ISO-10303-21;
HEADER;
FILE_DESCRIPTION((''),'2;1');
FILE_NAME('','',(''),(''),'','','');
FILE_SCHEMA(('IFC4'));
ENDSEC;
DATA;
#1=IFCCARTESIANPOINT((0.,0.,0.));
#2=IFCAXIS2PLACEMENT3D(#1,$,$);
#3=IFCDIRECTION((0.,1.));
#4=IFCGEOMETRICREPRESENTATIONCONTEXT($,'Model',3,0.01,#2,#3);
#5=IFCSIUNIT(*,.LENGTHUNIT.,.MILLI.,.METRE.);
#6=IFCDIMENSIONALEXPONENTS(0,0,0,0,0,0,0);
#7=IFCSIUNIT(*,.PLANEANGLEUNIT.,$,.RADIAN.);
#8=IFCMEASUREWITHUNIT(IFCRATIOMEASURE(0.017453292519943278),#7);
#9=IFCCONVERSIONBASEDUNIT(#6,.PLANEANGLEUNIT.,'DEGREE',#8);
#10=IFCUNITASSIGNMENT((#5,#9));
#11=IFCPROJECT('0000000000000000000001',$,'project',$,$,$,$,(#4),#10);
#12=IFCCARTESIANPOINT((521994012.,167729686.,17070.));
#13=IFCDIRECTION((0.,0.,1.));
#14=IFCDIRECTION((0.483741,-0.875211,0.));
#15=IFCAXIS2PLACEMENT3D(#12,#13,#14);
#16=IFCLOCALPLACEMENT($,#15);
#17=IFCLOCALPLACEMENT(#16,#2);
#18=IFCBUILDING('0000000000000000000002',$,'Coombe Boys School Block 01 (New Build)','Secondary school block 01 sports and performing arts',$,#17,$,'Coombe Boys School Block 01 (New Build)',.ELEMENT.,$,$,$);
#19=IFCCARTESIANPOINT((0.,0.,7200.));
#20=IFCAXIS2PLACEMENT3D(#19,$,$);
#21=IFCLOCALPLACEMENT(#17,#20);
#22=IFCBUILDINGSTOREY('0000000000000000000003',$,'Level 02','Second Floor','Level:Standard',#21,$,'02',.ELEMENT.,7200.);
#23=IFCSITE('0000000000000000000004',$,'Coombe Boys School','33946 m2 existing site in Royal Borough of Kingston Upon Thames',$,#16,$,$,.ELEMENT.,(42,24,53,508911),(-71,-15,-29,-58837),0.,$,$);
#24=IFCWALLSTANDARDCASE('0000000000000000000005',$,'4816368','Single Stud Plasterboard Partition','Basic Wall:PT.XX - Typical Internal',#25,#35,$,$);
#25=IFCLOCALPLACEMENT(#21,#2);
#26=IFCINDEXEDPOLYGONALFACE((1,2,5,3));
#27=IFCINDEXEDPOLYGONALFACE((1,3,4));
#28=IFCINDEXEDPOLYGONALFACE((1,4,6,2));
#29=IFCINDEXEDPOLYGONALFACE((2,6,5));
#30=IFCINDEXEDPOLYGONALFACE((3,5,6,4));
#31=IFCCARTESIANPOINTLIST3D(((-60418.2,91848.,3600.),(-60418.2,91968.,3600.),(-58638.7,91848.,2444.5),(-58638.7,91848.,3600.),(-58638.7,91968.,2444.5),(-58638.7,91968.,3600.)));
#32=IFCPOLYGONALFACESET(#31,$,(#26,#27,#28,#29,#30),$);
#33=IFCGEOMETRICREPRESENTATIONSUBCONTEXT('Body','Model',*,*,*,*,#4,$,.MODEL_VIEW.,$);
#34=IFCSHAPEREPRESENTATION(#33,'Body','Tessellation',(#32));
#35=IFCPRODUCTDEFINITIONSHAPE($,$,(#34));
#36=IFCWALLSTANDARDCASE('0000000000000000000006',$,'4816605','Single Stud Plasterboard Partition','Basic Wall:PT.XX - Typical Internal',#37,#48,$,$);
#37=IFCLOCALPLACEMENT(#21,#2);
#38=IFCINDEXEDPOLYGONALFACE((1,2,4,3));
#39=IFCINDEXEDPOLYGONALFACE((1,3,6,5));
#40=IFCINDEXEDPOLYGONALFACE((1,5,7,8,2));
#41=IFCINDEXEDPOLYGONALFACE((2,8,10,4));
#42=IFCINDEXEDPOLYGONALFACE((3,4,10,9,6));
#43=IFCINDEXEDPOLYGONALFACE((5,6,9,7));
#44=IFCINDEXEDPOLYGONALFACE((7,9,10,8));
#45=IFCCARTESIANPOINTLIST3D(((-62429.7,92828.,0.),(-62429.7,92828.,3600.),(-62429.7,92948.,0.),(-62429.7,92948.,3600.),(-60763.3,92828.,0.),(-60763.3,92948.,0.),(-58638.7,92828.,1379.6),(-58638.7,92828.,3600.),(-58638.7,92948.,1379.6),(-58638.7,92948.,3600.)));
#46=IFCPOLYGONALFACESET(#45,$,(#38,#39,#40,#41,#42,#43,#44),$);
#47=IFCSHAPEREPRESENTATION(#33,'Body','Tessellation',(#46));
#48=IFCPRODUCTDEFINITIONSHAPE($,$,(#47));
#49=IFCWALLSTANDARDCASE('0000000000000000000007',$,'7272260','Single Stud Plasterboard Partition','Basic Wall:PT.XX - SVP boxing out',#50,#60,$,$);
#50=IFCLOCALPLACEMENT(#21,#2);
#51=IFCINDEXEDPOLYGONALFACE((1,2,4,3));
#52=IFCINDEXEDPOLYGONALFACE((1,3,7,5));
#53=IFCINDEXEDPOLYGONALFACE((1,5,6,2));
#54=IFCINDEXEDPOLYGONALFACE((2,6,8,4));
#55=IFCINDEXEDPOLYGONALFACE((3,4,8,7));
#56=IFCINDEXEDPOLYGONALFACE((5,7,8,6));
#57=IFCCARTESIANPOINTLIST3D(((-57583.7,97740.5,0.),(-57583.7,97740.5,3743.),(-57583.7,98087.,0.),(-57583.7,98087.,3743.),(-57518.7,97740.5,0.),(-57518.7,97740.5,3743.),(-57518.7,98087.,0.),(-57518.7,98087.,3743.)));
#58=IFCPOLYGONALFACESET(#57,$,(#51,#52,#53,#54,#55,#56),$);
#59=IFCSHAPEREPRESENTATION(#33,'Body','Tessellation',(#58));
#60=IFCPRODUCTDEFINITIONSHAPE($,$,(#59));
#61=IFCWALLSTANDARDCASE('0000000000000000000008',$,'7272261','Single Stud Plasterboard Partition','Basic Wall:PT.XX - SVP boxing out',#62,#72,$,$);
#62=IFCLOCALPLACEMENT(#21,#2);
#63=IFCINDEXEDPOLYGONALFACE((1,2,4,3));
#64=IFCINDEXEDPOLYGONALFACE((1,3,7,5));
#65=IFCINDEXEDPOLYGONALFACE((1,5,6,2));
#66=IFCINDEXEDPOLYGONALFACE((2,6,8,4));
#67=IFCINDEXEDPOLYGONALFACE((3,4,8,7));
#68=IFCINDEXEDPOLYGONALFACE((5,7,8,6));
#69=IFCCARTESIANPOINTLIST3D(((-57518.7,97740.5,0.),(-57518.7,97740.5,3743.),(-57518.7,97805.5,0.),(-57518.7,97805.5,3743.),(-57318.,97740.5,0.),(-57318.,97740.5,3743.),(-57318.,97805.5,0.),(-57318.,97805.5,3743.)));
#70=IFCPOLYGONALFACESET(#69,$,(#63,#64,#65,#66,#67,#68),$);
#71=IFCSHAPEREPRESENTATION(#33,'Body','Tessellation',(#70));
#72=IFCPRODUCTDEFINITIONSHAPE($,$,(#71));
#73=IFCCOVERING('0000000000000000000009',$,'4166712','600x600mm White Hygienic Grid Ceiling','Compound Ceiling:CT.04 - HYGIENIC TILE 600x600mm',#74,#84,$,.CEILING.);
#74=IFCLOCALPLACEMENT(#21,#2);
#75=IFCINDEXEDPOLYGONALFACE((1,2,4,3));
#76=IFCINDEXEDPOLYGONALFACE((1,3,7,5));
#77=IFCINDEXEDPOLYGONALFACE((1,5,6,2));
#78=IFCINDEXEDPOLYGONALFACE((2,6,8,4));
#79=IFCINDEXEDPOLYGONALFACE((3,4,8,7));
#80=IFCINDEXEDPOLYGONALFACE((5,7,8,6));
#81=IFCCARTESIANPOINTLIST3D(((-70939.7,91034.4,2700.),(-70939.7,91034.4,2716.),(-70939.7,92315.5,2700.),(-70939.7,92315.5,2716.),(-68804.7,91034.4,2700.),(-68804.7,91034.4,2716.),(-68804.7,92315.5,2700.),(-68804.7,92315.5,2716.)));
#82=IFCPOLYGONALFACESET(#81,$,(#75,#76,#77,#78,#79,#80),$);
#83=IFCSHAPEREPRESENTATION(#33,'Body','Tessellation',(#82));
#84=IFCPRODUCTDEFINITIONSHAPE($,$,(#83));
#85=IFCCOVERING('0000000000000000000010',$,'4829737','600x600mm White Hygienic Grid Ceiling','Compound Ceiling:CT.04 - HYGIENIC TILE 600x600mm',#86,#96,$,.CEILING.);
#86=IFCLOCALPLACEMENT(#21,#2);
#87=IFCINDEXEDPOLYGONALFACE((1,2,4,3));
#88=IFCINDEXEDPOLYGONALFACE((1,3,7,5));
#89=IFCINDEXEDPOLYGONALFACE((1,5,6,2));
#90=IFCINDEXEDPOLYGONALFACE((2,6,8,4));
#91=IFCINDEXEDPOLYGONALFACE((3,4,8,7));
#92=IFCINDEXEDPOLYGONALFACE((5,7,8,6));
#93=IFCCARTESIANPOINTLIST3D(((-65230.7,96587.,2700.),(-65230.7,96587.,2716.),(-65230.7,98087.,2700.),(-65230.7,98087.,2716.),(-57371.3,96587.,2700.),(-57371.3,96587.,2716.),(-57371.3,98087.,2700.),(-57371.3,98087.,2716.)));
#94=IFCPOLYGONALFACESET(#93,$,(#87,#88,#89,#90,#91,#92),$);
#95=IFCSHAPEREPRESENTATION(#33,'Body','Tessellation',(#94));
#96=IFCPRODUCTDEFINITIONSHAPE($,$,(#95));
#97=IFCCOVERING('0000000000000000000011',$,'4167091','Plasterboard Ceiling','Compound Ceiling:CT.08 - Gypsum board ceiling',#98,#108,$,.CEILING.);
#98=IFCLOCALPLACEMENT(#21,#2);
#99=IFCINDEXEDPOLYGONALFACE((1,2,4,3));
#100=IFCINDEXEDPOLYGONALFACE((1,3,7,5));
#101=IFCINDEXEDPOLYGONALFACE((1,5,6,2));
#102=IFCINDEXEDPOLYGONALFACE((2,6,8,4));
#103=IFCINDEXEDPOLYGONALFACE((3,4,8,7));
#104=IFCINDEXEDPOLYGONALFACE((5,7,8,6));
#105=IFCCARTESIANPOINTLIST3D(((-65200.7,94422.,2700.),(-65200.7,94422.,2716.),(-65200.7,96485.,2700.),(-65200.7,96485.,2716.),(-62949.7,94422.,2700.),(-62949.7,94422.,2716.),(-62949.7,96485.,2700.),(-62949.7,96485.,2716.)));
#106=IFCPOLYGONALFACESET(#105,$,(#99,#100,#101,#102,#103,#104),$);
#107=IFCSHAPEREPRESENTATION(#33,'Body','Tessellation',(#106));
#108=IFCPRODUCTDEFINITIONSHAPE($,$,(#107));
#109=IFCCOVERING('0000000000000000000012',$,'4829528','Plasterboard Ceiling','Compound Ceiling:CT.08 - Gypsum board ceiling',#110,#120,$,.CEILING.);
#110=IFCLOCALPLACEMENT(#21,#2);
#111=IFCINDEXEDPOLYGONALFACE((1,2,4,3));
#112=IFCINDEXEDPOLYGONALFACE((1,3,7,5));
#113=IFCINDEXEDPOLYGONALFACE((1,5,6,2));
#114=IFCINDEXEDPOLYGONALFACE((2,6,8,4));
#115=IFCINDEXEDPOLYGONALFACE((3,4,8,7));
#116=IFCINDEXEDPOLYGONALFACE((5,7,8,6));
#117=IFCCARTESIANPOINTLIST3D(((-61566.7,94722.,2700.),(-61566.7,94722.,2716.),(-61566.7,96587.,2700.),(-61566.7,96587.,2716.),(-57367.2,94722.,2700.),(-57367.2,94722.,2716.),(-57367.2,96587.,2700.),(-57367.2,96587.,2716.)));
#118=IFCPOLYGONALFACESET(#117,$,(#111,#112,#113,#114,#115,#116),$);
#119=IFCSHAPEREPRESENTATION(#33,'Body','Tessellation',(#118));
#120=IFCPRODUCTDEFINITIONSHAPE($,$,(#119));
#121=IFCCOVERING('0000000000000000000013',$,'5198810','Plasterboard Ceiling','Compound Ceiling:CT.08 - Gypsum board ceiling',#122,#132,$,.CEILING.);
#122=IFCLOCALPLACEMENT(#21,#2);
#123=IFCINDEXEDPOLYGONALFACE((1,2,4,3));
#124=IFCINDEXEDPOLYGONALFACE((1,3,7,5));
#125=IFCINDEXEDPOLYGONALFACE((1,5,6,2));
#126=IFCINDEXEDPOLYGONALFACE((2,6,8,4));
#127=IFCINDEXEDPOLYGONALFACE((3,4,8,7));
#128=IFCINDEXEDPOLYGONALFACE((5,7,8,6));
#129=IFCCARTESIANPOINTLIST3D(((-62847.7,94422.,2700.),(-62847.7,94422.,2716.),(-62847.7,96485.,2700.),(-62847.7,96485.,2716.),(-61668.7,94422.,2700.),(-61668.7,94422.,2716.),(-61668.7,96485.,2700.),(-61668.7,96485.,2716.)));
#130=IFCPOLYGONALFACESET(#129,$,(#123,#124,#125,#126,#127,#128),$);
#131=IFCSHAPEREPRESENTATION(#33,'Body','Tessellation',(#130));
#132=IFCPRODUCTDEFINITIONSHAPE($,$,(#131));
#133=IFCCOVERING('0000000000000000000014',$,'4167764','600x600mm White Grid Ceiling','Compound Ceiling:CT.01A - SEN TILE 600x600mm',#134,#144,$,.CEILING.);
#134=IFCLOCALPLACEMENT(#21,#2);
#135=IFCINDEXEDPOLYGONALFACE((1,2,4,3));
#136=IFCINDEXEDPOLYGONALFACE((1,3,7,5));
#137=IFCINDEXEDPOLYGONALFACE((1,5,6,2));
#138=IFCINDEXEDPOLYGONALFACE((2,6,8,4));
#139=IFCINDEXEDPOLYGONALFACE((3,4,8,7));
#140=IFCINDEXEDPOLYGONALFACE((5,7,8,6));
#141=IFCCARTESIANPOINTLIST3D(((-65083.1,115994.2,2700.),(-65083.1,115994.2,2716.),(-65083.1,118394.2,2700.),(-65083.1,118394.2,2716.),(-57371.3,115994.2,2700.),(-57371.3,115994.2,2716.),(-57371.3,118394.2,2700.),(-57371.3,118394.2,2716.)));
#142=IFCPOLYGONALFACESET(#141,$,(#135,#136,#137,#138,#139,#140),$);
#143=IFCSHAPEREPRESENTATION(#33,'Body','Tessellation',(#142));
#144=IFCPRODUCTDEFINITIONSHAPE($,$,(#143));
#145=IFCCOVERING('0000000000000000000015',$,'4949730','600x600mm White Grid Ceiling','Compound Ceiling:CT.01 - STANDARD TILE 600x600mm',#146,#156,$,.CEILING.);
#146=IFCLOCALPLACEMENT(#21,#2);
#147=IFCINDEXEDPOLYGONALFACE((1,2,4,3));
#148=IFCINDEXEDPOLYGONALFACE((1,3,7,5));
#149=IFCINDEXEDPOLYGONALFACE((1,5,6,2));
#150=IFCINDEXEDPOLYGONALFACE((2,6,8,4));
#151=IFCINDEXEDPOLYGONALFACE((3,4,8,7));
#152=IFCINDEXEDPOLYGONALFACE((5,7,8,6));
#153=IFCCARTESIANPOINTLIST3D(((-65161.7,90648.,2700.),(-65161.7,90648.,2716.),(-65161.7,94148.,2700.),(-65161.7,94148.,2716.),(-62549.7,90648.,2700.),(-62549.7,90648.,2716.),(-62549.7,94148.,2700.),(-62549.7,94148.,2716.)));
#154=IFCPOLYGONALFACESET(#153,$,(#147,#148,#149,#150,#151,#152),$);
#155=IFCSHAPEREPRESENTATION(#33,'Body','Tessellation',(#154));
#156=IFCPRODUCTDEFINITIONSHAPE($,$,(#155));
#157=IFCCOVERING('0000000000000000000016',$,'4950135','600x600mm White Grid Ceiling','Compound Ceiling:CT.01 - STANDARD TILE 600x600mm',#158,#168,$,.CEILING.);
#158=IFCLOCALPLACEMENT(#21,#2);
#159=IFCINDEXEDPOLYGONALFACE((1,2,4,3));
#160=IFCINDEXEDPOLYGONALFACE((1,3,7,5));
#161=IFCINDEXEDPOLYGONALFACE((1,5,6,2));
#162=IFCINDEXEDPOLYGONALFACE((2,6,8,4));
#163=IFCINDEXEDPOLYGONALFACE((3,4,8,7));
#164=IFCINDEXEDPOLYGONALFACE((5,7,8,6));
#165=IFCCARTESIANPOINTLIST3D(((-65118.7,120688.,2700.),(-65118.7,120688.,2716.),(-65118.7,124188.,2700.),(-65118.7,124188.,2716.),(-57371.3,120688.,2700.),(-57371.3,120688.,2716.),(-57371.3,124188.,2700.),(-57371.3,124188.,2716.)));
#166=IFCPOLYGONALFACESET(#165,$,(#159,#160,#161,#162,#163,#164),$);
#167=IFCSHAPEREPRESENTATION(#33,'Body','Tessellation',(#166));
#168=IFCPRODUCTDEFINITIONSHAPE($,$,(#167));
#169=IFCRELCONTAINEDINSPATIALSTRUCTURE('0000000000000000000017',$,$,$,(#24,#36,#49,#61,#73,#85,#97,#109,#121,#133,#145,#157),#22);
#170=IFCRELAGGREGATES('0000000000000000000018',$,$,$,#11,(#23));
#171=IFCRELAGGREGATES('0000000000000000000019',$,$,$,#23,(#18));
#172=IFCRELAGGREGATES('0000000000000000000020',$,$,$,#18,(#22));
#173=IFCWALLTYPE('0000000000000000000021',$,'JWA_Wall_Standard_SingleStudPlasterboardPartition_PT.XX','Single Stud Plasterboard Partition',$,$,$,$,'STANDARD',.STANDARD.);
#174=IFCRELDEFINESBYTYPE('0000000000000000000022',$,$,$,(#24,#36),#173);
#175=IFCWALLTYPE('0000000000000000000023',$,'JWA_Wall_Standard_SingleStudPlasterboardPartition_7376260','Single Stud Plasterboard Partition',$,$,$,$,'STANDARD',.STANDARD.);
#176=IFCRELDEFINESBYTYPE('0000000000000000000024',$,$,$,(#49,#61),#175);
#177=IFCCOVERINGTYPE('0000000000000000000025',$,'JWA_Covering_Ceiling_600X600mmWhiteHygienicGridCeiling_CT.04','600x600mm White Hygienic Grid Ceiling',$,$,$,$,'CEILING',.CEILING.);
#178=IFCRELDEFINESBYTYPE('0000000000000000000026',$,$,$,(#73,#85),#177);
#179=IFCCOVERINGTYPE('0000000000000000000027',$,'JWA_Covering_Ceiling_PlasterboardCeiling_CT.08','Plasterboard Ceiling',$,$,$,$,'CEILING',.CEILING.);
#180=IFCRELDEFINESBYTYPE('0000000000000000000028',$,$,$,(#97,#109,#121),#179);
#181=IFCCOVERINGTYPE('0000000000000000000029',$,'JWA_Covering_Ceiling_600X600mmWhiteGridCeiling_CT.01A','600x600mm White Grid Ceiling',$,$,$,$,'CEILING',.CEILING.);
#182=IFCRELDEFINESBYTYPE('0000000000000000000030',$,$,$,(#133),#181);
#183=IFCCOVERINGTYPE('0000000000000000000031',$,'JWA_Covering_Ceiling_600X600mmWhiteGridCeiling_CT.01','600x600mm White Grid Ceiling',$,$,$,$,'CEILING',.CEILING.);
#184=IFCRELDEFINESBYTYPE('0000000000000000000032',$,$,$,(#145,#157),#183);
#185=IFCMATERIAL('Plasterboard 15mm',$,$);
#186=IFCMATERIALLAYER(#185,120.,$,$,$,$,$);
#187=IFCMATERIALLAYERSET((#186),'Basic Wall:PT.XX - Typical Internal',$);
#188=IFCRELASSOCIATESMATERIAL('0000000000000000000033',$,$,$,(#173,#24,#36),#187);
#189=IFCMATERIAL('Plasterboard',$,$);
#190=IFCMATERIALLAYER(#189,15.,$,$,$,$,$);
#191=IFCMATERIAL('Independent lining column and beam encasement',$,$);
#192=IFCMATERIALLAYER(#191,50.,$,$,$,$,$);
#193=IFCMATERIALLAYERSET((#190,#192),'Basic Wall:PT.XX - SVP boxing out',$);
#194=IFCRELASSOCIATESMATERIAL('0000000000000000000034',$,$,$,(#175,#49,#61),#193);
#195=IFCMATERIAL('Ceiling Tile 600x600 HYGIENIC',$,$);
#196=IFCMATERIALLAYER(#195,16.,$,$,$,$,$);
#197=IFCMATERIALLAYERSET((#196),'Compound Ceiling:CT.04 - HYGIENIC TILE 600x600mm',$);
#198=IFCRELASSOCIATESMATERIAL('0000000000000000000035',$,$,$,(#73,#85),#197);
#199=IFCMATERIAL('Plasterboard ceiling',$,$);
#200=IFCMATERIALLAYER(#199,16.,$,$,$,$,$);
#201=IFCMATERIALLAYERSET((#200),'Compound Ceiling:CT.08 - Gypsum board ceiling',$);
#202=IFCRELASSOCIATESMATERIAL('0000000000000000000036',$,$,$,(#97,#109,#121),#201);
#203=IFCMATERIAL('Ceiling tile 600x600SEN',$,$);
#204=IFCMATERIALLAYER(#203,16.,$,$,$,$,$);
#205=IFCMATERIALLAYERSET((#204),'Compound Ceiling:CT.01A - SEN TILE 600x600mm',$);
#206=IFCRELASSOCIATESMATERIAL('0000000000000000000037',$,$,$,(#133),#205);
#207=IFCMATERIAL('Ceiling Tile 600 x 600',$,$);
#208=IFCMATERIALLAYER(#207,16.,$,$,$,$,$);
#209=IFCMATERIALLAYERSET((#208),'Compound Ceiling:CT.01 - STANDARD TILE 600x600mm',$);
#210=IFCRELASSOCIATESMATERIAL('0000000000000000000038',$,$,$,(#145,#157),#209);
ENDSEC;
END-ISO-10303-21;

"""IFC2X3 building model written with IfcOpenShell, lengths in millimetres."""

from ifc_helpers import new_model, entity, si_unit, converted_unit, direction, frame, frame_2d, origin, place, context, subcontext, project, spatial, rectangle, extrude, clip, halfspace, material, layer, layer_set, layer_usage, type_object, element, save


model = new_model("IFC2X3")

# Units and contexts
model_context = context("Model", 3, precision=0.01, world=origin(), true_north=direction((0.0, 1.0)))
body_context = subcontext(model_context, "Body", "Model", "MODEL_VIEW")
ifc_project = project(units=[si_unit("LENGTHUNIT", "METRE", prefix="MILLI"), converted_unit("PLANEANGLEUNIT", "DEGREE", entity("IfcRatioMeasure", 0.017453292519943278), si_unit("PLANEANGLEUNIT", "RADIAN"), dimensions=[0, 0, 0, 0, 0, 0, 0])], contexts=[model_context])

# Site, building, storey
site_placement = place(None, frame((521994012.0, 167729686.0, 17070.0), z_axis=(0.0, 0.0, 1.0), x_axis=(0.483741, -0.875211, 0.0)))
site = spatial("IfcSite", under=ifc_project, at=site_placement, Name="Coombe Boys School", Description="33946 m2 existing site in Royal Borough of Kingston Upon Thames", CompositionType="ELEMENT", RefLatitude=(42, 24, 53, 508911), RefLongitude=(-71, -15, -29, -58837), RefElevation=0.0)
building_placement = place(site_placement, origin())
building = spatial("IfcBuilding", under=site, at=building_placement, Name="Coombe Boys School Block 01 (New Build)", Description="Secondary school block 01 sports and performing arts", LongName="Coombe Boys School Block 01 (New Build)", CompositionType="ELEMENT")
storey_placement = place(building_placement, frame((0.0, 0.0, 7200.0)))
storey = spatial("IfcBuildingStorey", under=building, at=storey_placement, Name="Level 02", Description="Second Floor", ObjectType="Level:Standard", LongName="02", CompositionType="ELEMENT", Elevation=7200.0)

# Shared definitions
ifc_material_1 = material(Name="Plasterboard 15mm")
ifc_layer_1 = layer(ifc_material_1, 120.0)
ifc_layer_set_1 = layer_set([ifc_layer_1], Name="Basic Wall:PT.XX - Typical Internal")
ifc_layer_usage_1 = layer_usage(ifc_layer_set_1, "AXIS2", "NEGATIVE", 60.0)
wall_type_1 = type_object("IfcWallType", Name="JWA_Wall_Standard_SingleStudPlasterboardPartition_PT.XX", Description="Single Stud Plasterboard Partition", ElementType="STANDARD", PredefinedType="STANDARD", material=ifc_layer_set_1)

# Walls
wall_1_placement = place(storey_placement, frame((-58638.7, 91908.0, 2444.5), z_axis=(0.0, 0.0, 1.0), x_axis=(-1.0, 0.0, 0.0)))
element("IfcWallStandardCase", 1, at=wall_1_placement, inside=storey, type_object=wall_type_1, material=ifc_layer_usage_1, Name="4816368", Description="Single Stud Plasterboard Partition", ObjectType="Basic Wall:PT.XX - Typical Internal", context=body_context, shape_type="Clipping", body=[
    clip(extrude(rectangle(XDim=1779.4, YDim=120.0, at=frame_2d((889.7, 0.0), x_axis=(-1.0, 0.0))), origin(), (0.0, 0.0, 1.0), 1155.5), halfspace(frame((1779.4, -60.0, 1155.5), z_axis=(0.544605, 0.0, -0.838692), x_axis=(0.0, 1.0, 0.0)), False)),
])
wall_2_placement = place(storey_placement, frame((-58638.7, 92888.0, 0.0), z_axis=(0.0, 0.0, 1.0), x_axis=(-1.0, 0.0, 0.0)))
element("IfcWallStandardCase", 2, at=wall_2_placement, inside=storey, type_object=wall_type_1, material=ifc_layer_usage_1, Name="4816605", Description="Single Stud Plasterboard Partition", ObjectType="Basic Wall:PT.XX - Typical Internal", context=body_context, shape_type="Clipping", body=[
    clip(extrude(rectangle(XDim=3791.0, YDim=120.0, at=frame_2d((1895.5, 0.0), x_axis=(-1.0, 0.0))), origin(), (0.0, 0.0, 1.0), 3600.0), halfspace(frame((2124.6, -60.0, 0.0), z_axis=(-0.544605, 0.0, -0.838692), x_axis=(0.0, 1.0, 0.0)), False)),
])
ifc_material_2 = material(Name="Plasterboard")
ifc_layer_2 = layer(ifc_material_2, 15.0)
ifc_material_3 = material(Name="Independent lining column and beam encasement")
ifc_layer_3 = layer(ifc_material_3, 50.0)
ifc_layer_set_2 = layer_set([ifc_layer_2, ifc_layer_3], Name="Basic Wall:PT.XX - SVP boxing out")
ifc_layer_usage_2 = layer_usage(ifc_layer_set_2, "AXIS2", "POSITIVE", -32.5)
wall_type_2 = type_object("IfcWallType", Name="JWA_Wall_Standard_SingleStudPlasterboardPartition_7376260", Description="Single Stud Plasterboard Partition", ElementType="STANDARD", PredefinedType="STANDARD", material=ifc_layer_set_2)
wall_3_placement = place(storey_placement, frame((-57551.2, 98087.0, 0.0), z_axis=(0.0, 0.0, 1.0), x_axis=(0.0, -1.0, 0.0)))
element("IfcWallStandardCase", 3, at=wall_3_placement, inside=storey, type_object=wall_type_2, material=ifc_layer_usage_2, Name="7272260", Description="Single Stud Plasterboard Partition", ObjectType="Basic Wall:PT.XX - SVP boxing out", context=body_context, shape_type="SweptSolid", body=[
    extrude(rectangle(XDim=346.5, YDim=65.0, at=frame_2d((173.3, 0.0), x_axis=(-1.0, 0.0))), origin(), (0.0, 0.0, 1.0), 3743.0),
])
wall_4_placement = place(storey_placement, frame((-57518.7, 97773.0, 0.0)))
element("IfcWallStandardCase", 4, at=wall_4_placement, inside=storey, type_object=wall_type_2, material=ifc_layer_usage_2, Name="7272261", Description="Single Stud Plasterboard Partition", ObjectType="Basic Wall:PT.XX - SVP boxing out", context=body_context, shape_type="SweptSolid", body=[
    extrude(rectangle(XDim=200.8, YDim=65.0, at=frame_2d((100.4, 0.0), x_axis=(-1.0, 0.0))), origin(), (0.0, 0.0, 1.0), 3743.0),
])

# Coverings
ifc_material_4 = material(Name="Ceiling Tile 600x600 HYGIENIC")
ifc_layer_4 = layer(ifc_material_4, 16.0)
ifc_layer_set_3 = layer_set([ifc_layer_4], Name="Compound Ceiling:CT.04 - HYGIENIC TILE 600x600mm")
ifc_layer_usage_3 = layer_usage(ifc_layer_set_3, "AXIS3", "POSITIVE", 0.0)
covering_type_1 = type_object("IfcCoveringType", Name="JWA_Covering_Ceiling_600X600mmWhiteHygienicGridCeiling_CT.04", Description="600x600mm White Hygienic Grid Ceiling", ElementType="CEILING", PredefinedType="CEILING")
covering_1_placement = place(storey_placement, origin())
element("IfcCovering", 5, at=covering_1_placement, inside=storey, type_object=covering_type_1, material=ifc_layer_usage_3, Name="4166712", Description="600x600mm White Hygienic Grid Ceiling", ObjectType="Compound Ceiling:CT.04 - HYGIENIC TILE 600x600mm", PredefinedType="CEILING", context=body_context, shape_type="SweptSolid", body=[
    extrude(rectangle(XDim=2135.0, YDim=1281.1, at=frame_2d((0.0, 0.0), x_axis=(1.0, 0.0))), frame((-69872.2, 91674.9, 2700.0)), (0.0, 0.0, 1.0), 16.0),
])
covering_2_placement = place(storey_placement, origin())
element("IfcCovering", 6, at=covering_2_placement, inside=storey, type_object=covering_type_1, material=ifc_layer_usage_3, Name="4829737", Description="600x600mm White Hygienic Grid Ceiling", ObjectType="Compound Ceiling:CT.04 - HYGIENIC TILE 600x600mm", PredefinedType="CEILING", context=body_context, shape_type="SweptSolid", body=[
    extrude(rectangle(XDim=7859.4, YDim=1500.0, at=frame_2d((0.0, 0.0), x_axis=(1.0, 0.0))), frame((-61301.0, 97337.0, 2700.0), z_axis=(0.0, 0.0, 1.0), x_axis=(-1.0, 0.0, 0.0)), (0.0, 0.0, 1.0), 16.0),
])
ifc_material_5 = material(Name="Plasterboard ceiling")
ifc_layer_5 = layer(ifc_material_5, 16.0)
ifc_layer_set_4 = layer_set([ifc_layer_5], Name="Compound Ceiling:CT.08 - Gypsum board ceiling")
ifc_layer_usage_4 = layer_usage(ifc_layer_set_4, "AXIS3", "POSITIVE", 0.0)
covering_type_2 = type_object("IfcCoveringType", Name="JWA_Covering_Ceiling_PlasterboardCeiling_CT.08", Description="Plasterboard Ceiling", ElementType="CEILING", PredefinedType="CEILING")
covering_3_placement = place(storey_placement, origin())
element("IfcCovering", 7, at=covering_3_placement, inside=storey, type_object=covering_type_2, material=ifc_layer_usage_4, Name="4167091", Description="Plasterboard Ceiling", ObjectType="Compound Ceiling:CT.08 - Gypsum board ceiling", PredefinedType="CEILING", context=body_context, shape_type="SweptSolid", body=[
    extrude(rectangle(XDim=2251.0, YDim=2063.0, at=frame_2d((0.0, 0.0), x_axis=(1.0, 0.0))), frame((-64075.2, 95453.5, 2700.0)), (0.0, 0.0, 1.0), 16.0),
])
covering_4_placement = place(storey_placement, origin())
element("IfcCovering", 8, at=covering_4_placement, inside=storey, type_object=covering_type_2, material=ifc_layer_usage_4, Name="4829528", Description="Plasterboard Ceiling", ObjectType="Compound Ceiling:CT.08 - Gypsum board ceiling", PredefinedType="CEILING", context=body_context, shape_type="SweptSolid", body=[
    extrude(rectangle(XDim=4199.5, YDim=1865.0, at=frame_2d((0.0, 0.0), x_axis=(1.0, 0.0))), frame((-59467.0, 95654.5, 2700.0), z_axis=(0.0, 0.0, 1.0), x_axis=(-1.0, 0.0, 0.0)), (0.0, 0.0, 1.0), 16.0),
])
covering_5_placement = place(storey_placement, origin())
element("IfcCovering", 9, at=covering_5_placement, inside=storey, type_object=covering_type_2, material=ifc_layer_usage_4, Name="5198810", Description="Plasterboard Ceiling", ObjectType="Compound Ceiling:CT.08 - Gypsum board ceiling", PredefinedType="CEILING", context=body_context, shape_type="SweptSolid", body=[
    extrude(rectangle(XDim=1179.0, YDim=2063.0, at=frame_2d((0.0, 0.0), x_axis=(1.0, 0.0))), frame((-62258.2, 95453.5, 2700.0), z_axis=(0.0, 0.0, 1.0), x_axis=(-1.0, 0.0, 0.0)), (0.0, 0.0, 1.0), 16.0),
])
ifc_material_6 = material(Name="Ceiling tile 600x600SEN")
ifc_layer_6 = layer(ifc_material_6, 16.0)
ifc_layer_set_5 = layer_set([ifc_layer_6], Name="Compound Ceiling:CT.01A - SEN TILE 600x600mm")
ifc_layer_usage_5 = layer_usage(ifc_layer_set_5, "AXIS3", "POSITIVE", 0.0)
covering_type_3 = type_object("IfcCoveringType", Name="JWA_Covering_Ceiling_600X600mmWhiteGridCeiling_CT.01A", Description="600x600mm White Grid Ceiling", ElementType="CEILING", PredefinedType="CEILING")
covering_6_placement = place(storey_placement, origin())
element("IfcCovering", 10, at=covering_6_placement, inside=storey, type_object=covering_type_3, material=ifc_layer_usage_5, Name="4167764", Description="600x600mm White Grid Ceiling", ObjectType="Compound Ceiling:CT.01A - SEN TILE 600x600mm", PredefinedType="CEILING", context=body_context, shape_type="SweptSolid", body=[
    extrude(rectangle(XDim=7711.8, YDim=2400.0, at=frame_2d((0.0, 0.0), x_axis=(1.0, 0.0))), frame((-61227.2, 117194.2, 2700.0), z_axis=(0.0, 0.0, 1.0), x_axis=(-1.0, 0.0, 0.0)), (0.0, 0.0, 1.0), 16.0),
])
ifc_material_7 = material(Name="Ceiling Tile 600 x 600")
ifc_layer_7 = layer(ifc_material_7, 16.0)
ifc_layer_set_6 = layer_set([ifc_layer_7], Name="Compound Ceiling:CT.01 - STANDARD TILE 600x600mm")
ifc_layer_usage_6 = layer_usage(ifc_layer_set_6, "AXIS3", "POSITIVE", 0.0)
covering_type_4 = type_object("IfcCoveringType", Name="JWA_Covering_Ceiling_600X600mmWhiteGridCeiling_CT.01", Description="600x600mm White Grid Ceiling", ElementType="CEILING", PredefinedType="CEILING")
covering_7_placement = place(storey_placement, origin())
element("IfcCovering", 11, at=covering_7_placement, inside=storey, type_object=covering_type_4, material=ifc_layer_usage_6, Name="4949730", Description="600x600mm White Grid Ceiling", ObjectType="Compound Ceiling:CT.01 - STANDARD TILE 600x600mm", PredefinedType="CEILING", context=body_context, shape_type="SweptSolid", body=[
    extrude(rectangle(XDim=2612.0, YDim=3500.0, at=frame_2d((0.0, 0.0), x_axis=(1.0, 0.0))), frame((-63855.7, 92398.0, 2700.0), z_axis=(0.0, 0.0, 1.0), x_axis=(-1.0, 0.0, 0.0)), (0.0, 0.0, 1.0), 16.0),
])
covering_8_placement = place(storey_placement, origin())
element("IfcCovering", 12, at=covering_8_placement, inside=storey, type_object=covering_type_4, material=ifc_layer_usage_6, Name="4950135", Description="600x600mm White Grid Ceiling", ObjectType="Compound Ceiling:CT.01 - STANDARD TILE 600x600mm", PredefinedType="CEILING", context=body_context, shape_type="SweptSolid", body=[
    extrude(rectangle(XDim=7747.4, YDim=3500.0, at=frame_2d((0.0, 0.0), x_axis=(1.0, 0.0))), frame((-61245.0, 122438.0, 2700.0), z_axis=(0.0, 0.0, 1.0), x_axis=(-1.0, 0.0, 0.0)), (0.0, 0.0, 1.0), 16.0),
])

save(model, "model.ifc")
